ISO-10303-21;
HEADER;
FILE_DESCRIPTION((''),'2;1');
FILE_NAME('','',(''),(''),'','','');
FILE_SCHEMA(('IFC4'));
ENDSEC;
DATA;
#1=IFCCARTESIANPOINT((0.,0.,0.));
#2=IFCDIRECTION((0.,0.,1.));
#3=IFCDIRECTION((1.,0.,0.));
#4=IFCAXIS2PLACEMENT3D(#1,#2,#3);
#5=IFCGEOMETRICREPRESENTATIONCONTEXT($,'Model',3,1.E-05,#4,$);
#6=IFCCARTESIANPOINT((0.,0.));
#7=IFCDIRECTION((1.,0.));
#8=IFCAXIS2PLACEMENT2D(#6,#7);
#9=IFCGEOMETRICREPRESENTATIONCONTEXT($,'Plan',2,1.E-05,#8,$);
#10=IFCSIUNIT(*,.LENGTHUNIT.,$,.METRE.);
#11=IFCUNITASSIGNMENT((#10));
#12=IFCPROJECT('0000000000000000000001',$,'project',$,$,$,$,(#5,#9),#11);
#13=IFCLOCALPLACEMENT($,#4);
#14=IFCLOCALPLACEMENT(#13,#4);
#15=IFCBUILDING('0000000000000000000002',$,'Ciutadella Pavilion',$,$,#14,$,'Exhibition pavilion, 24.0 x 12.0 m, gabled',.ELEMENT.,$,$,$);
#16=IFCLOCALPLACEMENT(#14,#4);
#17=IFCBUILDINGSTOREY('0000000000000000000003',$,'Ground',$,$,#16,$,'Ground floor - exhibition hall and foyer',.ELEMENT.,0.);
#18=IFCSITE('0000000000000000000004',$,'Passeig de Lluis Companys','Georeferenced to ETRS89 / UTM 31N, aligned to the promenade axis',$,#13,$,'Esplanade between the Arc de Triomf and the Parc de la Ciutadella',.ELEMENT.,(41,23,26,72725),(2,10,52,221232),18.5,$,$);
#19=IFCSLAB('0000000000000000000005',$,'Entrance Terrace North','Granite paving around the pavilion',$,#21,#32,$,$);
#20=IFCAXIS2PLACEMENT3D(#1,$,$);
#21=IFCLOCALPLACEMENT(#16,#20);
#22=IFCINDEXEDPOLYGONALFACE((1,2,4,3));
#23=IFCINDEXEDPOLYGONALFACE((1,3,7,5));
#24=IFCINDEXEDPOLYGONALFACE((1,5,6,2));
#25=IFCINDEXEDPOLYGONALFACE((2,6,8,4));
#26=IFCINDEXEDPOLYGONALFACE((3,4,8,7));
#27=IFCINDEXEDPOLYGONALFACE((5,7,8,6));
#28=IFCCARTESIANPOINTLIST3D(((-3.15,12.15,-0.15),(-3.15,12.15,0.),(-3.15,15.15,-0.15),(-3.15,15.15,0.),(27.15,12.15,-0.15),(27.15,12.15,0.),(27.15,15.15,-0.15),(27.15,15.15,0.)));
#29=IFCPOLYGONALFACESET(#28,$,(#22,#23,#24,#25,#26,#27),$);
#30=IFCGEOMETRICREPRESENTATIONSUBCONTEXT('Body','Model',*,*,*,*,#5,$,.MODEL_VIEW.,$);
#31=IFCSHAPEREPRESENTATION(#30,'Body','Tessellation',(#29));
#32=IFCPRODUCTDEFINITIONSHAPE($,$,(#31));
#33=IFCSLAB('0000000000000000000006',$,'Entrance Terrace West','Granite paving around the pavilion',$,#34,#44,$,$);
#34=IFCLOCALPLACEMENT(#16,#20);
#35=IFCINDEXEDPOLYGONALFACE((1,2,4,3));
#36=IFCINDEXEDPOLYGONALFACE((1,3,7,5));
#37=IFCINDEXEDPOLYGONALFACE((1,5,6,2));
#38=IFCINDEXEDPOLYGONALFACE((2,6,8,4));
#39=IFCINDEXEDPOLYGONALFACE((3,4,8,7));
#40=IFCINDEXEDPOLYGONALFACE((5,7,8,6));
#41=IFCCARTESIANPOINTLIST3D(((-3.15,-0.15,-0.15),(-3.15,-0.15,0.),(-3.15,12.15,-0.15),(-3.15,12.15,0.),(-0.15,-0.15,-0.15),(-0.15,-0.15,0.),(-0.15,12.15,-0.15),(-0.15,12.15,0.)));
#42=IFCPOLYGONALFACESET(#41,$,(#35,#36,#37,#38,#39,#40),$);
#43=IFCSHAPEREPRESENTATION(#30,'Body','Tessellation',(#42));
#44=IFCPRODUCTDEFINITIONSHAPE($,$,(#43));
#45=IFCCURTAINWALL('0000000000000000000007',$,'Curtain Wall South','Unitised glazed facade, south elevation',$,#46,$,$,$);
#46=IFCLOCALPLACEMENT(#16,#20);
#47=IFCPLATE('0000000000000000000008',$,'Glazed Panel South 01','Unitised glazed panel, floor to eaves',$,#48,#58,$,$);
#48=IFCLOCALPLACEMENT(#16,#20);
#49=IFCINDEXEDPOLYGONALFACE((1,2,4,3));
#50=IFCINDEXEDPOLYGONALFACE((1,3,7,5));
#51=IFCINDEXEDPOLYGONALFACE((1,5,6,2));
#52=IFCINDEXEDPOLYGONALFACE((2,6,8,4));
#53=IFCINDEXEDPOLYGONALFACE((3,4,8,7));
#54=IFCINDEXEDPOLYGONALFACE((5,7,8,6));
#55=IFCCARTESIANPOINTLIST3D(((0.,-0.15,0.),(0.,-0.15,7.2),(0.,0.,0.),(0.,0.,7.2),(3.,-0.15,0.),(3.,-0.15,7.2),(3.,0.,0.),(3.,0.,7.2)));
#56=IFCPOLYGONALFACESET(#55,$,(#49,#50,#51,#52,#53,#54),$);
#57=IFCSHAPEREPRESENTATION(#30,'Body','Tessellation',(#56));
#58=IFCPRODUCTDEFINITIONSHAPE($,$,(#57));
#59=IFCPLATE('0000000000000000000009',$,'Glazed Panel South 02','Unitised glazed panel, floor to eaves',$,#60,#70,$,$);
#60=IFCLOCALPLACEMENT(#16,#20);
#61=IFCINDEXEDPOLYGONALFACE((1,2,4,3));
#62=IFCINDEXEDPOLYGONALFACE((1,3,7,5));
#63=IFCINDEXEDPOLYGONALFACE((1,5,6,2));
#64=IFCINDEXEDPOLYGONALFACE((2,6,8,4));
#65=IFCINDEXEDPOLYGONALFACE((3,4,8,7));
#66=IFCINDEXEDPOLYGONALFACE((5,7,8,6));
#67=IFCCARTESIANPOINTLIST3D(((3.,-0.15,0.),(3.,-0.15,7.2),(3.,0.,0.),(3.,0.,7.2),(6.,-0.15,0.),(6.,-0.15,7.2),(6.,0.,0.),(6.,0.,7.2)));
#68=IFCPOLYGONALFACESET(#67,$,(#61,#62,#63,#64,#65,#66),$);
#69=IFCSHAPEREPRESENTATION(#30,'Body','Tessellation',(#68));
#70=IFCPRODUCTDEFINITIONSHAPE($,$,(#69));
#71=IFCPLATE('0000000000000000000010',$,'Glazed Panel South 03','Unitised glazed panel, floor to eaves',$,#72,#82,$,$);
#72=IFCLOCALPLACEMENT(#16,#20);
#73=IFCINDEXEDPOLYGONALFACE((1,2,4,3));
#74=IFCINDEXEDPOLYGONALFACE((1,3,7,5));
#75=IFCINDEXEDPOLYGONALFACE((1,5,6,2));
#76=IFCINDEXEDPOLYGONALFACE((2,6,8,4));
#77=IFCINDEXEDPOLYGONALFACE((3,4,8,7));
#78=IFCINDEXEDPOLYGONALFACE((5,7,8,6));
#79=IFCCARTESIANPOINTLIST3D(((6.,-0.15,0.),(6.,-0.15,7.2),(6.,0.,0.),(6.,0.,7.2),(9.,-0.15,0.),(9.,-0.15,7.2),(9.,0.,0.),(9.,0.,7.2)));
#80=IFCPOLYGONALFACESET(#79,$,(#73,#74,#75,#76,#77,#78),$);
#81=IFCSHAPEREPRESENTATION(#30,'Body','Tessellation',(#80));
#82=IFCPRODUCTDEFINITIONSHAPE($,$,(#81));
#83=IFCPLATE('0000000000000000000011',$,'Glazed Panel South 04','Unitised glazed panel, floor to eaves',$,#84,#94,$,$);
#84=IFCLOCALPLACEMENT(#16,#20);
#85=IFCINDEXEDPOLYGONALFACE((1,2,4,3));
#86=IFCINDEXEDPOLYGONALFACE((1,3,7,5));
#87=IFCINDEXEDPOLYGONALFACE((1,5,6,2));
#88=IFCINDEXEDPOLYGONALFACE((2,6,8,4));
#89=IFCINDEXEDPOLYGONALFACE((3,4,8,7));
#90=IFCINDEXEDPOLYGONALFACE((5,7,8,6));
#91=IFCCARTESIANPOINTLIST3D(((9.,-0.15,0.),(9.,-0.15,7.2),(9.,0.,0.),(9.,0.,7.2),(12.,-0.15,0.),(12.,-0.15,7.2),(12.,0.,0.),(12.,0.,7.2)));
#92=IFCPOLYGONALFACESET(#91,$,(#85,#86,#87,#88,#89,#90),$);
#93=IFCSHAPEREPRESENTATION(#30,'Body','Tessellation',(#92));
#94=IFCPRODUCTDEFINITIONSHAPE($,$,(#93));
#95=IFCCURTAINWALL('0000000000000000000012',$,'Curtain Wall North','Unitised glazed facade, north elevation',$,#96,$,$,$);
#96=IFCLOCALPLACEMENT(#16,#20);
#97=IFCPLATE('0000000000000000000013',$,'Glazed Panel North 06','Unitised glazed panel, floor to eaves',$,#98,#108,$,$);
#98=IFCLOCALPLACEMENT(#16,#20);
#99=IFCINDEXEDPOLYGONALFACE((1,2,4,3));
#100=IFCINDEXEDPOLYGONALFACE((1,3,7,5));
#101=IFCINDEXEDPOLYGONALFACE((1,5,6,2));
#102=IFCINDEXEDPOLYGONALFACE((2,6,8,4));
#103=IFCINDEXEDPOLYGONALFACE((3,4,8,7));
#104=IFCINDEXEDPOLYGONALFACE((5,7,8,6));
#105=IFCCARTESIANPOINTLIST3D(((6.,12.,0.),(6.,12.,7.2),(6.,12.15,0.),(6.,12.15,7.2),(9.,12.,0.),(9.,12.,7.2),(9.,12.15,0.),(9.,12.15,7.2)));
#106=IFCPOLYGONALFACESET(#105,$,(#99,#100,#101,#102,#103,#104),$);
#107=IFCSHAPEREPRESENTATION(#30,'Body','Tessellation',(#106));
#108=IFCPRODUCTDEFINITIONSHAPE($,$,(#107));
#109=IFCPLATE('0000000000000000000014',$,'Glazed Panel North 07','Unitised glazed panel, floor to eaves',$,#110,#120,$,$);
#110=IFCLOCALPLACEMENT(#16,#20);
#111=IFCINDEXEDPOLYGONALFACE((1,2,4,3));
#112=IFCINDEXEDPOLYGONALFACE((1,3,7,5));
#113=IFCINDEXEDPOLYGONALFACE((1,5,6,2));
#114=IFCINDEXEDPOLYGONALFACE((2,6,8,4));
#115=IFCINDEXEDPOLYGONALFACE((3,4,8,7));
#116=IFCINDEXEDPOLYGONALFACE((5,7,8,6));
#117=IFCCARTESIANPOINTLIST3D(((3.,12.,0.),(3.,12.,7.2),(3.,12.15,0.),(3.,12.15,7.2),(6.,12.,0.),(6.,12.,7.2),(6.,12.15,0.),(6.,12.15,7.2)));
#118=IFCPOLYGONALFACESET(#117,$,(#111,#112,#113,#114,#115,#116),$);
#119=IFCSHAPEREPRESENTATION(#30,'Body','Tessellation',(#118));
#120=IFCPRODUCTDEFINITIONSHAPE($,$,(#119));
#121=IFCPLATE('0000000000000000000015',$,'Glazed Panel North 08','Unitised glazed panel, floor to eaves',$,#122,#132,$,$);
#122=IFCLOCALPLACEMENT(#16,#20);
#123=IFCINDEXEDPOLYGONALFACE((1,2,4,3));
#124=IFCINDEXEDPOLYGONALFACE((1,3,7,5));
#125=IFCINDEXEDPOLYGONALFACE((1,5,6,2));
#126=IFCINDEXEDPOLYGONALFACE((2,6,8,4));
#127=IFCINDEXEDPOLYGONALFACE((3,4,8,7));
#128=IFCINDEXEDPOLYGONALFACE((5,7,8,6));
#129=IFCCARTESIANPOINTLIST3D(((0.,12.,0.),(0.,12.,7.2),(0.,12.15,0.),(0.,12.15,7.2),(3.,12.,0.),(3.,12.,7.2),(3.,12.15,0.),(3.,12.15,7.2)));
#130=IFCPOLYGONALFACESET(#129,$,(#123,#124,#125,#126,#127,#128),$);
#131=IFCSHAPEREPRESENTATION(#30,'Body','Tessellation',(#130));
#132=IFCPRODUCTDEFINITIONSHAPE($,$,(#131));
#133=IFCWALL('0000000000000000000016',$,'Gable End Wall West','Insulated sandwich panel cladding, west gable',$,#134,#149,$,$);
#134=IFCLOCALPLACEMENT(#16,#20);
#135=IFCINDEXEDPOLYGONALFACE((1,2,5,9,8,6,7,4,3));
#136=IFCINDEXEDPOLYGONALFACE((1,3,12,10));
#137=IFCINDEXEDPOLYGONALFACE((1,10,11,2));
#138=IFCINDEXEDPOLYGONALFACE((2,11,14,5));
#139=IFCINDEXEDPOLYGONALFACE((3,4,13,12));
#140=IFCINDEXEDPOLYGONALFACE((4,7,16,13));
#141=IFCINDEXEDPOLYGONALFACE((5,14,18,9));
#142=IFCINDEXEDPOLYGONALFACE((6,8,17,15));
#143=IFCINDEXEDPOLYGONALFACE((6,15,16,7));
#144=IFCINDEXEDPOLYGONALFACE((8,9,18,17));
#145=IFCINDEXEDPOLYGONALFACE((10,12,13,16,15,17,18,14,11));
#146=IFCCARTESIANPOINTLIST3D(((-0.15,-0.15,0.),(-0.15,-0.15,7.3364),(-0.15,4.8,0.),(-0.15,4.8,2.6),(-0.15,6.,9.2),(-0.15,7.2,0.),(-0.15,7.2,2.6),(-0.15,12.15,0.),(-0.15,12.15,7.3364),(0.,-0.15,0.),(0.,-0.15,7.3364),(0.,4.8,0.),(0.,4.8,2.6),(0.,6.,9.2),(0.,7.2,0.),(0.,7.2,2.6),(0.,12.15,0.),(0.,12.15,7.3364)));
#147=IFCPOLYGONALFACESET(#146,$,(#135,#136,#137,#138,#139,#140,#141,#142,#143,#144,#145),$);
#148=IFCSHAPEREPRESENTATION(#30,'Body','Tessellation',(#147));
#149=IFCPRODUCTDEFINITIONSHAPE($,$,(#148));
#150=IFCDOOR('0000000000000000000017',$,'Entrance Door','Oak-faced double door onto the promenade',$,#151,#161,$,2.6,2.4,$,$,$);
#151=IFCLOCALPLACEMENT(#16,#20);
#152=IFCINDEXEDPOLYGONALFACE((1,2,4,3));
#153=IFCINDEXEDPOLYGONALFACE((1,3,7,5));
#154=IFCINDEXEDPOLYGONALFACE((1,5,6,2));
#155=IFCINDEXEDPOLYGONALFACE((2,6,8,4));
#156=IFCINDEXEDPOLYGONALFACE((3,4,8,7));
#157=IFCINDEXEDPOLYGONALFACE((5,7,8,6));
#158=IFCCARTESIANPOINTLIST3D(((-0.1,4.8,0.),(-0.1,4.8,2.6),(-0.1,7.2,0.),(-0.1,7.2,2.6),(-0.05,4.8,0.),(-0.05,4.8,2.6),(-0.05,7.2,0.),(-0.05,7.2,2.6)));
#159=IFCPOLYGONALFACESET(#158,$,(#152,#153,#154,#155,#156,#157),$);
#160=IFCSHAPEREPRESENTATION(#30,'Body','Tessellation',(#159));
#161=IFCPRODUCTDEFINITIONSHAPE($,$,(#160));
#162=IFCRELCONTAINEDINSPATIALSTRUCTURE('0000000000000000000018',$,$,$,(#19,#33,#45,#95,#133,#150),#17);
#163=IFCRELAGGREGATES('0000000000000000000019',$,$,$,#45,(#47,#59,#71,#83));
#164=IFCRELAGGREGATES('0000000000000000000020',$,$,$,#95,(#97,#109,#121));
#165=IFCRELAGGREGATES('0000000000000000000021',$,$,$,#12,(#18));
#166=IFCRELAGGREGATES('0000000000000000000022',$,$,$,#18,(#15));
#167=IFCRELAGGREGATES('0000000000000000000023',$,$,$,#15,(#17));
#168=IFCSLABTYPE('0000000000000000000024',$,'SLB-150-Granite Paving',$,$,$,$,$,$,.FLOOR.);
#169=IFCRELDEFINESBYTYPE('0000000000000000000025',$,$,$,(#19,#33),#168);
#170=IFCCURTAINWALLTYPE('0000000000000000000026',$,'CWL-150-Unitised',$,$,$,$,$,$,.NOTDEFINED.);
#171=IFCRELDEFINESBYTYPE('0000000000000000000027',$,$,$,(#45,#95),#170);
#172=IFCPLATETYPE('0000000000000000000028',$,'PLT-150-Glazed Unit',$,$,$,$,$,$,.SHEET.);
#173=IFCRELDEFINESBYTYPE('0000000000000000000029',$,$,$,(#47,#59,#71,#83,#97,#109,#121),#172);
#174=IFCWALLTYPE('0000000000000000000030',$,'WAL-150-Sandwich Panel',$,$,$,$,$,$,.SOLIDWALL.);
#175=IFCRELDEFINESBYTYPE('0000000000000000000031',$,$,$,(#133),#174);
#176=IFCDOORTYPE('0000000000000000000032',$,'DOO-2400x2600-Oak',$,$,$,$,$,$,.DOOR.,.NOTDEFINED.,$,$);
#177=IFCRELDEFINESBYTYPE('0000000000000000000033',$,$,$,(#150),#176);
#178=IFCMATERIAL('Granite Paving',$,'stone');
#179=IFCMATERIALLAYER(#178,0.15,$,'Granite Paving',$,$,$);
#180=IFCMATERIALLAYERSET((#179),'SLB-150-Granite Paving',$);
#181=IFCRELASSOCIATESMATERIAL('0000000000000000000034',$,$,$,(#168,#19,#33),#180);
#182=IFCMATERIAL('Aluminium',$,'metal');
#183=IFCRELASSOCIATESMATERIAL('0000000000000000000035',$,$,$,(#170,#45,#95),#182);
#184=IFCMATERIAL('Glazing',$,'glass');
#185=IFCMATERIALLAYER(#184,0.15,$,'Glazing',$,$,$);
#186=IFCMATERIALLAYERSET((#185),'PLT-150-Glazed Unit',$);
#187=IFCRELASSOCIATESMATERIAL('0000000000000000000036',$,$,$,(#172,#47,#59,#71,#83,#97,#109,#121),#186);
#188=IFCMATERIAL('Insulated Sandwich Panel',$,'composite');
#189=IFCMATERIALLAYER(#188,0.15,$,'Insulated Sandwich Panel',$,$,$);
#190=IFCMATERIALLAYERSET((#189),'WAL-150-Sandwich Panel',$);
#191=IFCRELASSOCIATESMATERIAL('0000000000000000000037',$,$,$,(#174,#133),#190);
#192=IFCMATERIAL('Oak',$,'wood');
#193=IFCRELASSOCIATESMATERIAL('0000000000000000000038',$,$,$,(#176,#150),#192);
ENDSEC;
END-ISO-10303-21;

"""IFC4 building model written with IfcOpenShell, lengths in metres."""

from ifc_helpers import new_model, si_unit, frame, origin_with_axes, origin_2d_with_axis, place, context, subcontext, project, spatial, line, indexed_curve, outline, extrude, material, layer, layer_set, layer_usage, type_object, element, fill, aggregate, save


model = new_model("IFC4")

# Units and contexts
model_context = context("Model", 3, precision=1e-05, world=origin_with_axes())
plan_context = context("Plan", 2, precision=1e-05, world=origin_2d_with_axis())
body_context = subcontext(model_context, "Body", "Model", "MODEL_VIEW")
ifc_project = project(units=[si_unit("LENGTHUNIT", "METRE")], contexts=[model_context, plan_context])

# Site, building, storey
site_placement = place(None, origin_with_axes())
site = spatial("IfcSite", under=ifc_project, at=site_placement, Name="Passeig de Lluis Companys", Description="Georeferenced to ETRS89 / UTM 31N, aligned to the promenade axis", LongName="Esplanade between the Arc de Triomf and the Parc de la Ciutadella", CompositionType="ELEMENT", RefLatitude=(41, 23, 26, 72725), RefLongitude=(2, 10, 52, 221232), RefElevation=18.5)
building_placement = place(site_placement, origin_with_axes())
building = spatial("IfcBuilding", under=site, at=building_placement, Name="Ciutadella Pavilion", LongName="Exhibition pavilion, 24.0 x 12.0 m, gabled", CompositionType="ELEMENT")
storey_placement = place(building_placement, origin_with_axes())
storey = spatial("IfcBuildingStorey", under=building, at=storey_placement, Name="Ground", LongName="Ground floor - exhibition hall and foyer", CompositionType="ELEMENT", Elevation=0.0)

# Slabs
ifc_material_1 = material(Name="Granite Paving", Category="stone")
ifc_layer_1 = layer(ifc_material_1, 0.15, Name="Granite Paving")
ifc_layer_set_1 = layer_set([ifc_layer_1], Name="SLB-150-Granite Paving")
slab_type_1 = type_object("IfcSlabType", Name="SLB-150-Granite Paving", PredefinedType="FLOOR", material=ifc_layer_set_1)
ifc_layer_usage_1 = layer_usage(ifc_layer_set_1, "AXIS3", "POSITIVE", 0.0)
slab_1_placement = place(storey_placement, frame((-3.15, 12.15, -0.15), z_axis=(0.0, 0.0, 1.0), x_axis=(1.0, 0.0, 0.0)))
element("IfcSlab", 1, at=slab_1_placement, inside=storey, type_object=slab_type_1, material=ifc_layer_usage_1, Name="Entrance Terrace North", Description="Granite paving around the pavilion", context=body_context, shape_type="SweptSolid", body=[
    extrude(outline(indexed_curve([(0.0, 0.0), (30.3, 0.0), (30.3, 3.0), (0.0, 3.0)], segments=[line(1, 2, 3, 4, 1)])), origin_with_axes(), (0.0, 0.0, 1.0), 0.15),
])
ifc_layer_usage_2 = layer_usage(ifc_layer_set_1, "AXIS3", "POSITIVE", 0.0)
slab_2_placement = place(storey_placement, frame((-3.15, -0.15, -0.15), z_axis=(0.0, 0.0, 1.0), x_axis=(1.0, 0.0, 0.0)))
element("IfcSlab", 2, at=slab_2_placement, inside=storey, type_object=slab_type_1, material=ifc_layer_usage_2, Name="Entrance Terrace West", Description="Granite paving around the pavilion", context=body_context, shape_type="SweptSolid", body=[
    extrude(outline(indexed_curve([(0.0, 0.0), (3.0, 0.0), (3.0, 12.3), (0.0, 12.3)], segments=[line(1, 2, 3, 4, 1)])), origin_with_axes(), (0.0, 0.0, 1.0), 0.15),
])

# Curtain walls, plates
ifc_material_2 = material(Name="Aluminium", Category="metal")
curtain_wall_type = type_object("IfcCurtainWallType", Name="CWL-150-Unitised", PredefinedType="NOTDEFINED", material=ifc_material_2)
curtain_wall_1_placement = place(storey_placement, frame((0.0, -0.15, 0.0), z_axis=(0.0, 0.0, 1.0), x_axis=(1.0, 0.0, 0.0)))
curtain_wall_1 = element("IfcCurtainWall", 3, at=curtain_wall_1_placement, inside=storey, type_object=curtain_wall_type, material=ifc_material_2, Name="Curtain Wall South", Description="Unitised glazed facade, south elevation")
ifc_material_3 = material(Name="Glazing", Category="glass")
ifc_layer_2 = layer(ifc_material_3, 0.15, Name="Glazing")
ifc_layer_set_2 = layer_set([ifc_layer_2], Name="PLT-150-Glazed Unit")
ifc_layer_usage_3 = layer_usage(ifc_layer_set_2, "AXIS2", "POSITIVE", 0.0)
plate_type = type_object("IfcPlateType", Name="PLT-150-Glazed Unit", PredefinedType="SHEET", material=ifc_layer_set_2)
plate_1_placement = place(curtain_wall_1_placement, origin_with_axes())
plate_1 = element("IfcPlate", 4, at=plate_1_placement, type_object=plate_type, material=ifc_layer_usage_3, Name="Glazed Panel South 01", Description="Unitised glazed panel, floor to eaves", context=body_context, shape_type="SweptSolid", body=[
    extrude(outline(indexed_curve([(0.0, 0.0), (3.0, 0.0), (3.0, 0.15), (0.0, 0.15)], segments=[line(1, 2, 3, 4, 1)])), origin_with_axes(), (0.0, 0.0, 1.0), 7.2),
])
ifc_layer_usage_4 = layer_usage(ifc_layer_set_2, "AXIS2", "POSITIVE", 0.0)
plate_2_placement = place(curtain_wall_1_placement, frame((3.0, 0.0, 0.0), z_axis=(0.0, 0.0, 1.0), x_axis=(1.0, 0.0, 0.0)))
plate_2 = element("IfcPlate", 5, at=plate_2_placement, type_object=plate_type, material=ifc_layer_usage_4, Name="Glazed Panel South 02", Description="Unitised glazed panel, floor to eaves", context=body_context, shape_type="SweptSolid", body=[
    extrude(outline(indexed_curve([(0.0, 0.0), (3.0, 0.0), (3.0, 0.15), (0.0, 0.15)], segments=[line(1, 2, 3, 4, 1)])), origin_with_axes(), (0.0, 0.0, 1.0), 7.2),
])
ifc_layer_usage_5 = layer_usage(ifc_layer_set_2, "AXIS2", "POSITIVE", 0.0)
plate_3_placement = place(curtain_wall_1_placement, frame((6.0, 0.0, 0.0), z_axis=(0.0, 0.0, 1.0), x_axis=(1.0, 0.0, 0.0)))
plate_3 = element("IfcPlate", 6, at=plate_3_placement, type_object=plate_type, material=ifc_layer_usage_5, Name="Glazed Panel South 03", Description="Unitised glazed panel, floor to eaves", context=body_context, shape_type="SweptSolid", body=[
    extrude(outline(indexed_curve([(0.0, 0.0), (3.0, 0.0), (3.0, 0.15), (0.0, 0.15)], segments=[line(1, 2, 3, 4, 1)])), origin_with_axes(), (0.0, 0.0, 1.0), 7.2),
])
ifc_layer_usage_6 = layer_usage(ifc_layer_set_2, "AXIS2", "POSITIVE", 0.0)
plate_4_placement = place(curtain_wall_1_placement, frame((9.0, 0.0, 0.0), z_axis=(0.0, 0.0, 1.0), x_axis=(1.0, 0.0, 0.0)))
plate_4 = element("IfcPlate", 7, at=plate_4_placement, type_object=plate_type, material=ifc_layer_usage_6, Name="Glazed Panel South 04", Description="Unitised glazed panel, floor to eaves", context=body_context, shape_type="SweptSolid", body=[
    extrude(outline(indexed_curve([(0.0, 0.0), (3.0, 0.0), (3.0, 0.15), (0.0, 0.15)], segments=[line(1, 2, 3, 4, 1)])), origin_with_axes(), (0.0, 0.0, 1.0), 7.2),
])
aggregate(curtain_wall_1, [plate_1, plate_2, plate_3, plate_4])
curtain_wall_2_placement = place(storey_placement, frame((24.0, 12.15, 0.0), z_axis=(0.0, 0.0, 1.0), x_axis=(-1.0, 0.0, 0.0)))
curtain_wall_2 = element("IfcCurtainWall", 8, at=curtain_wall_2_placement, inside=storey, type_object=curtain_wall_type, material=ifc_material_2, Name="Curtain Wall North", Description="Unitised glazed facade, north elevation")
ifc_layer_usage_7 = layer_usage(ifc_layer_set_2, "AXIS2", "POSITIVE", 0.0)
plate_5_placement = place(curtain_wall_2_placement, frame((15.0, 0.0, 0.0), z_axis=(0.0, 0.0, 1.0), x_axis=(1.0, 0.0, 0.0)))
plate_5 = element("IfcPlate", 9, at=plate_5_placement, type_object=plate_type, material=ifc_layer_usage_7, Name="Glazed Panel North 06", Description="Unitised glazed panel, floor to eaves", context=body_context, shape_type="SweptSolid", body=[
    extrude(outline(indexed_curve([(0.0, 0.0), (3.0, 0.0), (3.0, 0.15), (0.0, 0.15)], segments=[line(1, 2, 3, 4, 1)])), origin_with_axes(), (0.0, 0.0, 1.0), 7.2),
])
ifc_layer_usage_8 = layer_usage(ifc_layer_set_2, "AXIS2", "POSITIVE", 0.0)
plate_6_placement = place(curtain_wall_2_placement, frame((18.0, 0.0, 0.0), z_axis=(0.0, 0.0, 1.0), x_axis=(1.0, 0.0, 0.0)))
plate_6 = element("IfcPlate", 10, at=plate_6_placement, type_object=plate_type, material=ifc_layer_usage_8, Name="Glazed Panel North 07", Description="Unitised glazed panel, floor to eaves", context=body_context, shape_type="SweptSolid", body=[
    extrude(outline(indexed_curve([(0.0, 0.0), (3.0, 0.0), (3.0, 0.15), (0.0, 0.15)], segments=[line(1, 2, 3, 4, 1)])), origin_with_axes(), (0.0, 0.0, 1.0), 7.2),
])
ifc_layer_usage_9 = layer_usage(ifc_layer_set_2, "AXIS2", "POSITIVE", 0.0)
plate_7_placement = place(curtain_wall_2_placement, frame((21.0, 0.0, 0.0), z_axis=(0.0, 0.0, 1.0), x_axis=(1.0, 0.0, 0.0)))
plate_7 = element("IfcPlate", 11, at=plate_7_placement, type_object=plate_type, material=ifc_layer_usage_9, Name="Glazed Panel North 08", Description="Unitised glazed panel, floor to eaves", context=body_context, shape_type="SweptSolid", body=[
    extrude(outline(indexed_curve([(0.0, 0.0), (3.0, 0.0), (3.0, 0.15), (0.0, 0.15)], segments=[line(1, 2, 3, 4, 1)])), origin_with_axes(), (0.0, 0.0, 1.0), 7.2),
])
aggregate(curtain_wall_2, [plate_5, plate_6, plate_7])

# Wall, opening, door
ifc_material_4 = material(Name="Insulated Sandwich Panel", Category="composite")
ifc_layer_3 = layer(ifc_material_4, 0.15, Name="Insulated Sandwich Panel")
ifc_layer_set_3 = layer_set([ifc_layer_3], Name="WAL-150-Sandwich Panel")
ifc_layer_usage_10 = layer_usage(ifc_layer_set_3, "AXIS2", "POSITIVE", 0.0)
wall_type = type_object("IfcWallType", Name="WAL-150-Sandwich Panel", PredefinedType="SOLIDWALL", material=ifc_layer_set_3)
wall_placement = place(storey_placement, frame((-0.15, -0.15, 0.0), z_axis=(1.0, 0.0, 0.0), x_axis=(0.0, 1.0, 0.0)))
wall = element("IfcWall", 12, at=wall_placement, inside=storey, type_object=wall_type, material=ifc_layer_usage_10, Name="Gable End Wall West", Description="Insulated sandwich panel cladding, west gable", context=body_context, shape_type="SweptSolid", body=[
    extrude(outline(indexed_curve([(0.0, 0.0), (12.3, 0.0), (12.3, 7.3364), (6.15, 9.2), (0.0, 7.3364)], segments=[line(1, 2, 3, 4, 5, 1)])), origin_with_axes(), (0.0, 0.0, 1.0), 0.15),
])
opening_placement = place(wall_placement, frame((4.95, 0.0, -0.01), z_axis=(0.0, 1.0, 0.0), x_axis=(0.0, 0.0, 1.0)))
opening = element("IfcOpeningElement", 13, at=opening_placement, cuts=wall, PredefinedType="OPENING", context=body_context, shape_type="SweptSolid", body=[
    extrude(outline(indexed_curve([(0.0, 0.0), (0.17, 0.0), (0.17, 2.4), (0.0, 2.4)], segments=[line(1, 2, 3, 4, 1)])), origin_with_axes(), (0.0, 0.0, 1.0), 2.6),
])
ifc_material_5 = material(Name="Oak", Category="wood")
door_type = type_object("IfcDoorType", Name="DOO-2400x2600-Oak", OperationType="NOTDEFINED", PredefinedType="DOOR", material=ifc_material_5)
door_placement = place(storey_placement, frame((-0.1, 4.8, 0.0), z_axis=(0.0, 0.0, 1.0), x_axis=(1.0, 0.0, 0.0)))
door = element("IfcDoor", 14, at=door_placement, inside=storey, type_object=door_type, material=ifc_material_5, Name="Entrance Door", Description="Oak-faced double door onto the promenade", OverallHeight=2.6, OverallWidth=2.4, context=body_context, shape_type="SweptSolid", body=[
    extrude(outline(indexed_curve([(0.0, 0.0), (0.05, 0.0), (0.05, 2.4), (0.0, 2.4)], segments=[line(1, 2, 3, 4, 1)])), origin_with_axes(), (0.0, 0.0, 1.0), 2.6),
])
fill(opening, door)

save(model, "model.ifc")
